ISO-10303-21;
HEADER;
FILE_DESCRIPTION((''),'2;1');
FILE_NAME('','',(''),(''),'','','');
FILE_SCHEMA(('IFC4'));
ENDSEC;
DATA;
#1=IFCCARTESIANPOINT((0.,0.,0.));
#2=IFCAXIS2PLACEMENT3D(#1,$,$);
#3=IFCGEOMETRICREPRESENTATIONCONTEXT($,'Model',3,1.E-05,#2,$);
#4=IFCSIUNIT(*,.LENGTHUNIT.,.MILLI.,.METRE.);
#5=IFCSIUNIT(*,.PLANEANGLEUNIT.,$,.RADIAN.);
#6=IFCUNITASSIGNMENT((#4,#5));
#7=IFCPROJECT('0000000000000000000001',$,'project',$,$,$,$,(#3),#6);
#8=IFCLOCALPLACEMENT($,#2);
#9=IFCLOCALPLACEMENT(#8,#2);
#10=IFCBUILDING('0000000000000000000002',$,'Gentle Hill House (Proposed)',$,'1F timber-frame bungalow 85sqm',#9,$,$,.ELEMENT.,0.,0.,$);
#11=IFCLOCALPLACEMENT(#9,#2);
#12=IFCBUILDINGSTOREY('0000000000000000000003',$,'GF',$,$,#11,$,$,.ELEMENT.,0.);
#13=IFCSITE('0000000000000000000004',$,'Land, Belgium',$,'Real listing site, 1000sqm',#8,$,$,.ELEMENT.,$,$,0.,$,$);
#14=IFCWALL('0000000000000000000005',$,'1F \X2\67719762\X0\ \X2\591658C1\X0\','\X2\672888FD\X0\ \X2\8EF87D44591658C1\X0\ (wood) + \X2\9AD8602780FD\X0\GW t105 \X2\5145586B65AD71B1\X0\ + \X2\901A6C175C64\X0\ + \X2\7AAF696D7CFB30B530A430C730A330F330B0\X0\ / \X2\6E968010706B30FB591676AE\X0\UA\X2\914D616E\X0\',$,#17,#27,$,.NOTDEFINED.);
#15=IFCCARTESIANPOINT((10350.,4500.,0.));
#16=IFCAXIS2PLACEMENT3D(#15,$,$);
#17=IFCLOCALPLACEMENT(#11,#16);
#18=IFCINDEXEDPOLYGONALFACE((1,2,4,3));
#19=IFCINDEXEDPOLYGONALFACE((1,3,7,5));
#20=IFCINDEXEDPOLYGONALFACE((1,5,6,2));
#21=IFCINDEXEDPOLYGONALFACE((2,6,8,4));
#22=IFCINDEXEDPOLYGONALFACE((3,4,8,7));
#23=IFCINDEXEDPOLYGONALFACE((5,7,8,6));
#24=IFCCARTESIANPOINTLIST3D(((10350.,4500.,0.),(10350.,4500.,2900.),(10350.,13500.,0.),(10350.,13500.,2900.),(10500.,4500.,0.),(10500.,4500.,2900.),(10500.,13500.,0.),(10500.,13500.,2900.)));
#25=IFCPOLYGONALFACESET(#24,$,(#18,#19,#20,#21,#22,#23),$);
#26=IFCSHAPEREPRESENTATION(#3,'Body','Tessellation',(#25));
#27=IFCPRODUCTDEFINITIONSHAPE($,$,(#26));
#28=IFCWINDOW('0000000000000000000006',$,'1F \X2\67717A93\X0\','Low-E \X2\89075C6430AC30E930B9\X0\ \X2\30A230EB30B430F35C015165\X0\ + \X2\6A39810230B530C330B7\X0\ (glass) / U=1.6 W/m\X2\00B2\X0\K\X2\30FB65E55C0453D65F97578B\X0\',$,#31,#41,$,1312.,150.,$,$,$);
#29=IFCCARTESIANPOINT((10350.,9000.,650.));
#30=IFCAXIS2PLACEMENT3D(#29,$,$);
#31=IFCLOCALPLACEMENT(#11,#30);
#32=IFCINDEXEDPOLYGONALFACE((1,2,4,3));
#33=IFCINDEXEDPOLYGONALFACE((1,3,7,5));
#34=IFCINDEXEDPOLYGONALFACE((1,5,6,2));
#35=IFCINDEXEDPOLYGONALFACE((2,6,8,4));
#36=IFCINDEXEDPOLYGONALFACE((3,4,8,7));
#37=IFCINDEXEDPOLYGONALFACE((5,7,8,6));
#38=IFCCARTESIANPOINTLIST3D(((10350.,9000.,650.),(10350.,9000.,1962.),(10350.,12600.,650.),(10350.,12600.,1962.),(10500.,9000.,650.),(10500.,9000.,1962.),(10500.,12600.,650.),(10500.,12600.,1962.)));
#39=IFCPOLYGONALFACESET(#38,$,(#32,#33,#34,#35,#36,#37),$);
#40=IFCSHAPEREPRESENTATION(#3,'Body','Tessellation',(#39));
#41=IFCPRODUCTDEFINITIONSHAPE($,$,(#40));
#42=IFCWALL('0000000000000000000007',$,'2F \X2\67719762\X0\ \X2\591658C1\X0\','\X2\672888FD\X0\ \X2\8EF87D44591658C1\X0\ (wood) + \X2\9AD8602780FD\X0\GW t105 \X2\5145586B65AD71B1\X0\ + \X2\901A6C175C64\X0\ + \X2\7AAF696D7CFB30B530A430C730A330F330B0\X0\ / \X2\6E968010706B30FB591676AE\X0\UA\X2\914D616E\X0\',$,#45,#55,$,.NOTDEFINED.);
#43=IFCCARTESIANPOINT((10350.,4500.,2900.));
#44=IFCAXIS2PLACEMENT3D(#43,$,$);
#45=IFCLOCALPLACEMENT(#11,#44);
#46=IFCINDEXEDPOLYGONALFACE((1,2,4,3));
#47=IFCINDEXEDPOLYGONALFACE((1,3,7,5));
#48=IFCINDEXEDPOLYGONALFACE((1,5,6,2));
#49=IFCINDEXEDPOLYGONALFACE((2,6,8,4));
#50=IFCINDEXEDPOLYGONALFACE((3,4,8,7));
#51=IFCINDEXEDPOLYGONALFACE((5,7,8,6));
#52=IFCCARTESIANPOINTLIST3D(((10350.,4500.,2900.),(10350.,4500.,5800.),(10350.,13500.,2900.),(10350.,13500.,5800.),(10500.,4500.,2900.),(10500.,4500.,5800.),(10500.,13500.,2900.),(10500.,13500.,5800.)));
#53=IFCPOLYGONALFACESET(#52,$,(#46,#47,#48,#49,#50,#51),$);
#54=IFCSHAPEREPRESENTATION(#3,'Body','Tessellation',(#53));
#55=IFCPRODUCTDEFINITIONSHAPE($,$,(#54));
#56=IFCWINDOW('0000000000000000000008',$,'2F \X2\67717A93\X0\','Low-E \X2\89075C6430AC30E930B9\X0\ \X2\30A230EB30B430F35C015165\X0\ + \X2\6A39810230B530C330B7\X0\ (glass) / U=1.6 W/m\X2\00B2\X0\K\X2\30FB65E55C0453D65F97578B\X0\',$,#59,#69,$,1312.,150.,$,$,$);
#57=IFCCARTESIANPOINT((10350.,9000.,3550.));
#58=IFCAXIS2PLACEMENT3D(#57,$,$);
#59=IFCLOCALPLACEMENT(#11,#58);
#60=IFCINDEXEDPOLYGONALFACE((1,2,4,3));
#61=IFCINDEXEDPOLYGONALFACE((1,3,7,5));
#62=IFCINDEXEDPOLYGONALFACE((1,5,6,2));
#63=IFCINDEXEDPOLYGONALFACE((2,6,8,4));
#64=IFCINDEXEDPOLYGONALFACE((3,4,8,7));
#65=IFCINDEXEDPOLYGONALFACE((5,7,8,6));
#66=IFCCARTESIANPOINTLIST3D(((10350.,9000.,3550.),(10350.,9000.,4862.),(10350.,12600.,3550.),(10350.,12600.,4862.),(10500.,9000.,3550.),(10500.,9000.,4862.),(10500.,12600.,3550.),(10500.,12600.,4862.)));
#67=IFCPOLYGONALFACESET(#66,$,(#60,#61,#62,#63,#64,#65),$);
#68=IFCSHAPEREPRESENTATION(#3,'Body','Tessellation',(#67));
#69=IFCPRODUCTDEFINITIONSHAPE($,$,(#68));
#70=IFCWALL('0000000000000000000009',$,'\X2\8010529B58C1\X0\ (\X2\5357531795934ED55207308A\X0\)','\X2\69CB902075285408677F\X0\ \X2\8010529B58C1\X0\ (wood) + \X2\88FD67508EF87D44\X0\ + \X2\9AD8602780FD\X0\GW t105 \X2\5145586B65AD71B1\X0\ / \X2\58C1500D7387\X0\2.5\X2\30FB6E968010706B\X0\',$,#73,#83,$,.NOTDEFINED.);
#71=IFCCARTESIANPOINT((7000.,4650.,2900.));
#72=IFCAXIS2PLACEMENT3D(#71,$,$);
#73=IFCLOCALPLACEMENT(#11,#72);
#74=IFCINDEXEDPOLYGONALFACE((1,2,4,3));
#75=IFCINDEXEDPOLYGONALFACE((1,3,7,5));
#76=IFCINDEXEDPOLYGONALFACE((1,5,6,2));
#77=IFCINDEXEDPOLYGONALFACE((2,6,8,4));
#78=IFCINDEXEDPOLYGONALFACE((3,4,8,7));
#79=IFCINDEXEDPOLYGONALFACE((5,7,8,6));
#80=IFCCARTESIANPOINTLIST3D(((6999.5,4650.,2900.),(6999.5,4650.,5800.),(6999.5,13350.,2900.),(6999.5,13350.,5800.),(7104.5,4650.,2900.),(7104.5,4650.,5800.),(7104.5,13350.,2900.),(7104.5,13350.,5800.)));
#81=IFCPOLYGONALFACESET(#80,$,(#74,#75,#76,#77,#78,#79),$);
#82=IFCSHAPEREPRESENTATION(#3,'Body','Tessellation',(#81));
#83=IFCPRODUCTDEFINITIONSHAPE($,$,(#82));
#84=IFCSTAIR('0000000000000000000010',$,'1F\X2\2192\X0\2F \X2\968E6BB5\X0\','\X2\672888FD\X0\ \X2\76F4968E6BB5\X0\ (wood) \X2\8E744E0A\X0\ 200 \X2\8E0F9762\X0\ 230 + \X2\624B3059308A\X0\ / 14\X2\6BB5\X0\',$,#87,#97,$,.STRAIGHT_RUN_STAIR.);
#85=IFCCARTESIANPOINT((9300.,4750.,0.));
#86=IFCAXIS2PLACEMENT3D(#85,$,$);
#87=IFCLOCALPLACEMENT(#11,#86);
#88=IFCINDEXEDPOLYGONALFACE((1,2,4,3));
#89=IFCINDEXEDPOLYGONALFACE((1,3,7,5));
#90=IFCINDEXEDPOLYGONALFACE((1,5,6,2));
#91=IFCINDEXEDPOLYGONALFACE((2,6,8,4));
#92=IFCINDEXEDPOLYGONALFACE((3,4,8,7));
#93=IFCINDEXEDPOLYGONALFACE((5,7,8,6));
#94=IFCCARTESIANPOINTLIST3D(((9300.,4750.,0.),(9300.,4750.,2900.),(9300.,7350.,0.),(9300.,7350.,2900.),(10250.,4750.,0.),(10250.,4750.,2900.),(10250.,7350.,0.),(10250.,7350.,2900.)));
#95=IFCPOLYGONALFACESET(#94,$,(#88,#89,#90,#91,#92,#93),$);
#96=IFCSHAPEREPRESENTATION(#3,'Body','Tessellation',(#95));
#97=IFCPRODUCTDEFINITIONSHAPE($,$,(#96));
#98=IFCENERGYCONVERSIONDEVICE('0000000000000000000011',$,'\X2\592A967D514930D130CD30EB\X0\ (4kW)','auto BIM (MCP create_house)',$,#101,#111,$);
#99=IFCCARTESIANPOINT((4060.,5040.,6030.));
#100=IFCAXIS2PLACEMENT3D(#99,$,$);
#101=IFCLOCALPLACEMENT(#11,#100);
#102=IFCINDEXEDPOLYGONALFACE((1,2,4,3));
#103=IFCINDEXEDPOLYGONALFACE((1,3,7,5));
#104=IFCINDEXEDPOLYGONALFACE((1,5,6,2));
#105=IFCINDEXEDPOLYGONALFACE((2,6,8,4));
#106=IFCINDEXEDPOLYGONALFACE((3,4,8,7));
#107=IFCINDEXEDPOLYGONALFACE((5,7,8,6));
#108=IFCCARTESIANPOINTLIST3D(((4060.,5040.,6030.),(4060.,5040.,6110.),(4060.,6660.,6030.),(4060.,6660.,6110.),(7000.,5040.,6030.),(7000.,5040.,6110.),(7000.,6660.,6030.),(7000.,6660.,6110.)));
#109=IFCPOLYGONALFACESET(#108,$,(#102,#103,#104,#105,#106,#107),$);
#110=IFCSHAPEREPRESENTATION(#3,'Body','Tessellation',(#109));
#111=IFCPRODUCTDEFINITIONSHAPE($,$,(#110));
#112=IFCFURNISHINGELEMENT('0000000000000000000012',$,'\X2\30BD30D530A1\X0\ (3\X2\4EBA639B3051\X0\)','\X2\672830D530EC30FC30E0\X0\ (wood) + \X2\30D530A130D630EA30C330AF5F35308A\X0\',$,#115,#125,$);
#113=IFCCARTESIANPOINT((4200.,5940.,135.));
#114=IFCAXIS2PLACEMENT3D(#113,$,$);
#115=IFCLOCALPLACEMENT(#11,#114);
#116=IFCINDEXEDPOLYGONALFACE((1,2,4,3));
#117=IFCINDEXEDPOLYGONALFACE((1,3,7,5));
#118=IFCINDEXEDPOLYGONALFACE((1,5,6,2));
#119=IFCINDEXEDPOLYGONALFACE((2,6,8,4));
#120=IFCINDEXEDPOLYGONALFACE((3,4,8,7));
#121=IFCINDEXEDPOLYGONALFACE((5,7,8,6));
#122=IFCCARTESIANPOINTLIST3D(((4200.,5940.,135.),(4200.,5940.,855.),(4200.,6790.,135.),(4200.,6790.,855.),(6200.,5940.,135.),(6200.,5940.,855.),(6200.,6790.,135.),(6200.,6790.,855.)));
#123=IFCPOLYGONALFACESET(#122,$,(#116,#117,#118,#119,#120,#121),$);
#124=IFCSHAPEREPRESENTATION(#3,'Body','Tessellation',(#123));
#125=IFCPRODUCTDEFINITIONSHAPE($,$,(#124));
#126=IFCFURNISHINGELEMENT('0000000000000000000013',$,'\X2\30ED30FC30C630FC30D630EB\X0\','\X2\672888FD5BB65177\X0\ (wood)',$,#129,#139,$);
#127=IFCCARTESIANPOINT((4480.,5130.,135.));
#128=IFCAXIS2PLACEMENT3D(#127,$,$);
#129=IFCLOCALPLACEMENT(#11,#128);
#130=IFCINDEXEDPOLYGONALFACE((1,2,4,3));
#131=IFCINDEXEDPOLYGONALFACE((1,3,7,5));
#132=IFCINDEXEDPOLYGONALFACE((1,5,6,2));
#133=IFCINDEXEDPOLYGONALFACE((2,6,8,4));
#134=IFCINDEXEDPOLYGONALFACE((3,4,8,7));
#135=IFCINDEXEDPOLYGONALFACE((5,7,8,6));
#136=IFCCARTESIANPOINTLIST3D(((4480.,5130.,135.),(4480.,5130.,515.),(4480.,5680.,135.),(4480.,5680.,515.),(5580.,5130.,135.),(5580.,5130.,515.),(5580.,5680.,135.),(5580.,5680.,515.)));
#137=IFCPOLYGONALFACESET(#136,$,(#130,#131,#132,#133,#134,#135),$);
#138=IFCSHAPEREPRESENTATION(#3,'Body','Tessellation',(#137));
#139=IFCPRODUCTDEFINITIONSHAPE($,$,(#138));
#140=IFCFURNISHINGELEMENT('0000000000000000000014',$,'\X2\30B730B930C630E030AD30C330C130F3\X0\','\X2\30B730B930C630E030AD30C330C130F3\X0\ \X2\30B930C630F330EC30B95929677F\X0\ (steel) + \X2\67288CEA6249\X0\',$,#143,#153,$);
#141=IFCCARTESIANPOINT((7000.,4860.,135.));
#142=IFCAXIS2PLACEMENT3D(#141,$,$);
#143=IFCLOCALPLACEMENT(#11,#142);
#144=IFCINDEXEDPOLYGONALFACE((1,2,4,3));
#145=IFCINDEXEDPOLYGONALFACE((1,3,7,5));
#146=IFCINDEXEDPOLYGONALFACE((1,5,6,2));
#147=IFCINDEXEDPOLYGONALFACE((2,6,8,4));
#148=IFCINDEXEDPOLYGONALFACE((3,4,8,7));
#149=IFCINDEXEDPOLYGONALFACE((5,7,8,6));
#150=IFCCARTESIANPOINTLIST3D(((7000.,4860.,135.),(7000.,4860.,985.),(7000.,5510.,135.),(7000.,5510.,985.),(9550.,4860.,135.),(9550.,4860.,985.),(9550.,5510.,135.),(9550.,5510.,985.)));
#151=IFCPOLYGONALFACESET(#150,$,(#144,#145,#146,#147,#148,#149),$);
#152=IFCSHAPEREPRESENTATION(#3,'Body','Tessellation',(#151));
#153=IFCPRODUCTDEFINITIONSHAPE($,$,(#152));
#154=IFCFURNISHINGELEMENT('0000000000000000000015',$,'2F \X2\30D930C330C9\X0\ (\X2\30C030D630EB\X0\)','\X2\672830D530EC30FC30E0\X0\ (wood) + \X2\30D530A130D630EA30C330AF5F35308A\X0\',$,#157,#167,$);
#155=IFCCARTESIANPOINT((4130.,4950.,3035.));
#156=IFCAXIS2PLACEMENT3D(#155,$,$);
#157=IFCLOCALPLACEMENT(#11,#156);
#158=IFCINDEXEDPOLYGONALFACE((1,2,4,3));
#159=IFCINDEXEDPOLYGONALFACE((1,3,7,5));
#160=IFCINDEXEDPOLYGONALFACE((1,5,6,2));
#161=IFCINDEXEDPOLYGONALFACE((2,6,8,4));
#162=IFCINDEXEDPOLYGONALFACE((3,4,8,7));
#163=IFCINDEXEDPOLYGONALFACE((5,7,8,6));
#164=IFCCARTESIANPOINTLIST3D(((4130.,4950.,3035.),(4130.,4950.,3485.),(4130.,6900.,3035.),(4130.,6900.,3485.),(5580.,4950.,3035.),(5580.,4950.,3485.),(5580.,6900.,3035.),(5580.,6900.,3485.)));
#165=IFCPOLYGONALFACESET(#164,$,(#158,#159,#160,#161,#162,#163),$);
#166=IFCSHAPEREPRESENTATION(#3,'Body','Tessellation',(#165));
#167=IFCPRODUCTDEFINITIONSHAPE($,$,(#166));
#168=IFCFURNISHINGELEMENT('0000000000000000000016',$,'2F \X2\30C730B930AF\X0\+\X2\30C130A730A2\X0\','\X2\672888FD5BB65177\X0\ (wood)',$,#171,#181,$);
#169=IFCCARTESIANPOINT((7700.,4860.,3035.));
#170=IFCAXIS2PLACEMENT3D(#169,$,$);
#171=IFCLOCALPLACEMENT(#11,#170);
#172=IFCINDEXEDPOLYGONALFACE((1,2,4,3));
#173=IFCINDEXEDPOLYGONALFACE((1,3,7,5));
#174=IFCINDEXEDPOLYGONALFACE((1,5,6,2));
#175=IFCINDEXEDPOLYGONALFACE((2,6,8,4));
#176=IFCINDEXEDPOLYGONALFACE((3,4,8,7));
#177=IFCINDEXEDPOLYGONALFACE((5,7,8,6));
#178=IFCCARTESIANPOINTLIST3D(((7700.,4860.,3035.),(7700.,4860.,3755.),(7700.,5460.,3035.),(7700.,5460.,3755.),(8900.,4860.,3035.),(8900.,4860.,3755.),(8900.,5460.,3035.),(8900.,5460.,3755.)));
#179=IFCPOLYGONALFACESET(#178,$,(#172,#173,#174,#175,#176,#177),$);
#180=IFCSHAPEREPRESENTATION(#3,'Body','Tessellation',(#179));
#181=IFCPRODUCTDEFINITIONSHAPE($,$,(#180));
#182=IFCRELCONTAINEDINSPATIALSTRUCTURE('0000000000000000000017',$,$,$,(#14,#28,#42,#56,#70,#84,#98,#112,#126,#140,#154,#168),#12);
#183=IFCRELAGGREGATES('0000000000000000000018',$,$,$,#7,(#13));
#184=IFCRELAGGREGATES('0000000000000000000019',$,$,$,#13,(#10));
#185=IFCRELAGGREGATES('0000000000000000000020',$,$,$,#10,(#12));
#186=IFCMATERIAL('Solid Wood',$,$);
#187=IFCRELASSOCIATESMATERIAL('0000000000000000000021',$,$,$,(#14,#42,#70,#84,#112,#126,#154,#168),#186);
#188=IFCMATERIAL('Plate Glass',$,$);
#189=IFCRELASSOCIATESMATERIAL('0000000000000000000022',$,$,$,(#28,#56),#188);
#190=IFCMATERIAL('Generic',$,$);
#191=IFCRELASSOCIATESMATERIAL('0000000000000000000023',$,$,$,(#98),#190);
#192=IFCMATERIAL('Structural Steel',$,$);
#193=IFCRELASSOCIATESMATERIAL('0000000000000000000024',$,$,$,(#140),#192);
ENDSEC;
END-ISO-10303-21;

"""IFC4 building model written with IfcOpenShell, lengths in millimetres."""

from ifc_helpers import new_model, si_unit, frame, frame_2d, origin, place, context, project, spatial, rectangle, extrude, material, element, fill, save


model = new_model("IFC4")

# Units and contexts
model_context = context("Model", 3, precision=1e-05, world=origin())
ifc_project = project(units=[si_unit("LENGTHUNIT", "METRE", prefix="MILLI"), si_unit("PLANEANGLEUNIT", "RADIAN")], contexts=[model_context])

# Site, building, storey
site_placement = place(None, origin())
site = spatial("IfcSite", under=ifc_project, at=site_placement, Name="Land, Belgium", ObjectType="Real listing site, 1000sqm", CompositionType="ELEMENT", RefElevation=0.0)
building_placement = place(site_placement, origin())
building = spatial("IfcBuilding", under=site, at=building_placement, Name="Gentle Hill House (Proposed)", ObjectType="1F timber-frame bungalow 85sqm", CompositionType="ELEMENT", ElevationOfRefHeight=0.0, ElevationOfTerrain=0.0)
storey_placement = place(building_placement, origin())
storey = spatial("IfcBuildingStorey", under=building, at=storey_placement, Name="GF", CompositionType="ELEMENT", Elevation=0.0)

# Wall, opening, window
ifc_material_1 = material(Name="Solid Wood")
wall_1_placement = place(storey_placement, frame((10350.0, 4500.0, 0.0)))
wall_1 = element("IfcWall", 1, at=wall_1_placement, inside=storey, material=ifc_material_1, Name="1F 東面 外壁", Description="木製 軸組外壁 (wood) + 高性能GW t105 充填断熱 + 通気層 + 窯業系サイディング / 準耐火・外皮UA配慮", PredefinedType="NOTDEFINED", context=model_context, shape_type="SweptSolid", body=[
    extrude(rectangle(XDim=150.0, YDim=9000.0, at=frame_2d((75.0, 4500.0))), frame((10350.0, 4500.0, 0.0)), (0.0, 0.0, 1.0), 2900.0),
])
opening_1_placement = place(storey_placement, frame((10350.0, 9000.0, 650.0)))
opening_1 = element("IfcOpeningElement", 2, at=opening_1_placement, cuts=wall_1, PredefinedType="NOTDEFINED", context=model_context, shape_type="SweptSolid", body=[
    extrude(rectangle(XDim=150.0, YDim=3600.0, at=frame_2d((75.0, 1800.0))), frame((10350.0, 9000.0, 650.0)), (0.0, 0.0, 1.0), 1312.0),
])
ifc_material_2 = material(Name="Plate Glass")
window_1_placement = place(storey_placement, frame((10350.0, 9000.0, 650.0)))
window_1 = element("IfcWindow", 3, at=window_1_placement, inside=storey, material=ifc_material_2, Name="1F 東窓", Description="Low-E 複層ガラス アルゴン封入 + 樹脂サッシ (glass) / U=1.6 W/m²K・日射取得型", OverallHeight=1312.0, OverallWidth=150.0, context=model_context, shape_type="SweptSolid", body=[
    extrude(rectangle(XDim=150.0, YDim=3600.0, at=frame_2d((75.0, 1800.0))), frame((10350.0, 9000.0, 650.0)), (0.0, 0.0, 1.0), 1312.0),
])
fill(opening_1, window_1)

# Wall, opening, window
wall_2_placement = place(storey_placement, frame((10350.0, 4500.0, 2900.0)))
wall_2 = element("IfcWall", 4, at=wall_2_placement, inside=storey, material=ifc_material_1, Name="2F 東面 外壁", Description="木製 軸組外壁 (wood) + 高性能GW t105 充填断熱 + 通気層 + 窯業系サイディング / 準耐火・外皮UA配慮", PredefinedType="NOTDEFINED", context=model_context, shape_type="SweptSolid", body=[
    extrude(rectangle(XDim=150.0, YDim=9000.0, at=frame_2d((75.0, 4500.0))), frame((10350.0, 4500.0, 2900.0)), (0.0, 0.0, 1.0), 2900.0),
])
opening_2_placement = place(storey_placement, frame((10350.0, 9000.0, 3550.0)))
opening_2 = element("IfcOpeningElement", 5, at=opening_2_placement, cuts=wall_2, PredefinedType="NOTDEFINED", context=model_context, shape_type="SweptSolid", body=[
    extrude(rectangle(XDim=150.0, YDim=3600.0, at=frame_2d((75.0, 1800.0))), frame((10350.0, 9000.0, 3550.0)), (0.0, 0.0, 1.0), 1312.0),
])
window_2_placement = place(storey_placement, frame((10350.0, 9000.0, 3550.0)))
window_2 = element("IfcWindow", 6, at=window_2_placement, inside=storey, material=ifc_material_2, Name="2F 東窓", Description="Low-E 複層ガラス アルゴン封入 + 樹脂サッシ (glass) / U=1.6 W/m²K・日射取得型", OverallHeight=1312.0, OverallWidth=150.0, context=model_context, shape_type="SweptSolid", body=[
    extrude(rectangle(XDim=150.0, YDim=3600.0, at=frame_2d((75.0, 1800.0))), frame((10350.0, 9000.0, 3550.0)), (0.0, 0.0, 1.0), 1312.0),
])
fill(opening_2, window_2)

# Wall
wall_3_placement = place(storey_placement, frame((7000.0, 4650.0, 2900.0)))
element("IfcWall", 7, at=wall_3_placement, inside=storey, material=ifc_material_1, Name="耐力壁 (南北間仕切り)", Description="構造用合板 耐力壁 (wood) + 製材軸組 + 高性能GW t105 充填断熱 / 壁倍率2.5・準耐火", PredefinedType="NOTDEFINED", context=model_context, shape_type="SweptSolid", body=[
    extrude(rectangle(XDim=105.0, YDim=8700.0, at=frame_2d((52.0, 4350.0))), frame((7000.0, 4650.0, 2900.0)), (0.0, 0.0, 1.0), 2900.0),
])

# Stair
stair_placement = place(storey_placement, frame((9300.0, 4750.0, 0.0)))
element("IfcStair", 8, at=stair_placement, inside=storey, material=ifc_material_1, Name="1F→2F 階段", Description="木製 直階段 (wood) 蹴上 200 踏面 230 + 手すり / 14段", PredefinedType="STRAIGHT_RUN_STAIR", context=model_context, shape_type="SweptSolid", body=[
    extrude(rectangle(XDim=950.0, YDim=2600.0, at=frame_2d((475.0, 1300.0))), frame((9300.0, 4750.0, 0.0)), (0.0, 0.0, 1.0), 2900.0),
])

# Energy conversion device
ifc_material_3 = material(Name="Generic")
energy_conversion_device_placement = place(storey_placement, frame((4060.0, 5040.0, 6030.0)))
element("IfcEnergyConversionDevice", 9, at=energy_conversion_device_placement, inside=storey, material=ifc_material_3, Name="太陽光パネル (4kW)", Description="auto BIM (MCP create_house)", context=model_context, shape_type="SweptSolid", body=[
    extrude(rectangle(XDim=2940.0, YDim=1620.0, at=frame_2d((1470.0, 810.0))), frame((4060.0, 5040.0, 6030.0)), (0.0, 0.0, 1.0), 80.0),
])

# Furnishing elements
furnishing_1_placement = place(storey_placement, frame((4200.0, 5940.0, 135.0)))
element("IfcFurnishingElement", 10, at=furnishing_1_placement, inside=storey, material=ifc_material_1, Name="ソファ (3人掛け)", Description="木フレーム (wood) + ファブリック張り", context=model_context, shape_type="SweptSolid", body=[
    extrude(rectangle(XDim=2000.0, YDim=850.0, at=frame_2d((1000.0, 425.0))), frame((4200.0, 5940.0, 135.0)), (0.0, 0.0, 1.0), 720.0),
])
furnishing_2_placement = place(storey_placement, frame((4480.0, 5130.0, 135.0)))
element("IfcFurnishingElement", 11, at=furnishing_2_placement, inside=storey, material=ifc_material_1, Name="ローテーブル", Description="木製家具 (wood)", context=model_context, shape_type="SweptSolid", body=[
    extrude(rectangle(XDim=1100.0, YDim=550.0, at=frame_2d((550.0, 275.0))), frame((4480.0, 5130.0, 135.0)), (0.0, 0.0, 1.0), 380.0),
])
ifc_material_4 = material(Name="Structural Steel")
furnishing_3_placement = place(storey_placement, frame((7000.0, 4860.0, 135.0)))
element("IfcFurnishingElement", 12, at=furnishing_3_placement, inside=storey, material=ifc_material_4, Name="システムキッチン", Description="システムキッチン ステンレス天板 (steel) + 木質扉", context=model_context, shape_type="SweptSolid", body=[
    extrude(rectangle(XDim=2550.0, YDim=650.0, at=frame_2d((1275.0, 325.0))), frame((7000.0, 4860.0, 135.0)), (0.0, 0.0, 1.0), 850.0),
])
furnishing_4_placement = place(storey_placement, frame((4130.0, 4950.0, 3035.0)))
element("IfcFurnishingElement", 13, at=furnishing_4_placement, inside=storey, material=ifc_material_1, Name="2F ベッド (ダブル)", Description="木フレーム (wood) + ファブリック張り", context=model_context, shape_type="SweptSolid", body=[
    extrude(rectangle(XDim=1450.0, YDim=1950.0, at=frame_2d((725.0, 975.0))), frame((4130.0, 4950.0, 3035.0)), (0.0, 0.0, 1.0), 450.0),
])
furnishing_5_placement = place(storey_placement, frame((7700.0, 4860.0, 3035.0)))
element("IfcFurnishingElement", 14, at=furnishing_5_placement, inside=storey, material=ifc_material_1, Name="2F デスク+チェア", Description="木製家具 (wood)", context=model_context, shape_type="SweptSolid", body=[
    extrude(rectangle(XDim=1200.0, YDim=600.0, at=frame_2d((600.0, 300.0))), frame((7700.0, 4860.0, 3035.0)), (0.0, 0.0, 1.0), 720.0),
])

save(model, "model.ifc")
